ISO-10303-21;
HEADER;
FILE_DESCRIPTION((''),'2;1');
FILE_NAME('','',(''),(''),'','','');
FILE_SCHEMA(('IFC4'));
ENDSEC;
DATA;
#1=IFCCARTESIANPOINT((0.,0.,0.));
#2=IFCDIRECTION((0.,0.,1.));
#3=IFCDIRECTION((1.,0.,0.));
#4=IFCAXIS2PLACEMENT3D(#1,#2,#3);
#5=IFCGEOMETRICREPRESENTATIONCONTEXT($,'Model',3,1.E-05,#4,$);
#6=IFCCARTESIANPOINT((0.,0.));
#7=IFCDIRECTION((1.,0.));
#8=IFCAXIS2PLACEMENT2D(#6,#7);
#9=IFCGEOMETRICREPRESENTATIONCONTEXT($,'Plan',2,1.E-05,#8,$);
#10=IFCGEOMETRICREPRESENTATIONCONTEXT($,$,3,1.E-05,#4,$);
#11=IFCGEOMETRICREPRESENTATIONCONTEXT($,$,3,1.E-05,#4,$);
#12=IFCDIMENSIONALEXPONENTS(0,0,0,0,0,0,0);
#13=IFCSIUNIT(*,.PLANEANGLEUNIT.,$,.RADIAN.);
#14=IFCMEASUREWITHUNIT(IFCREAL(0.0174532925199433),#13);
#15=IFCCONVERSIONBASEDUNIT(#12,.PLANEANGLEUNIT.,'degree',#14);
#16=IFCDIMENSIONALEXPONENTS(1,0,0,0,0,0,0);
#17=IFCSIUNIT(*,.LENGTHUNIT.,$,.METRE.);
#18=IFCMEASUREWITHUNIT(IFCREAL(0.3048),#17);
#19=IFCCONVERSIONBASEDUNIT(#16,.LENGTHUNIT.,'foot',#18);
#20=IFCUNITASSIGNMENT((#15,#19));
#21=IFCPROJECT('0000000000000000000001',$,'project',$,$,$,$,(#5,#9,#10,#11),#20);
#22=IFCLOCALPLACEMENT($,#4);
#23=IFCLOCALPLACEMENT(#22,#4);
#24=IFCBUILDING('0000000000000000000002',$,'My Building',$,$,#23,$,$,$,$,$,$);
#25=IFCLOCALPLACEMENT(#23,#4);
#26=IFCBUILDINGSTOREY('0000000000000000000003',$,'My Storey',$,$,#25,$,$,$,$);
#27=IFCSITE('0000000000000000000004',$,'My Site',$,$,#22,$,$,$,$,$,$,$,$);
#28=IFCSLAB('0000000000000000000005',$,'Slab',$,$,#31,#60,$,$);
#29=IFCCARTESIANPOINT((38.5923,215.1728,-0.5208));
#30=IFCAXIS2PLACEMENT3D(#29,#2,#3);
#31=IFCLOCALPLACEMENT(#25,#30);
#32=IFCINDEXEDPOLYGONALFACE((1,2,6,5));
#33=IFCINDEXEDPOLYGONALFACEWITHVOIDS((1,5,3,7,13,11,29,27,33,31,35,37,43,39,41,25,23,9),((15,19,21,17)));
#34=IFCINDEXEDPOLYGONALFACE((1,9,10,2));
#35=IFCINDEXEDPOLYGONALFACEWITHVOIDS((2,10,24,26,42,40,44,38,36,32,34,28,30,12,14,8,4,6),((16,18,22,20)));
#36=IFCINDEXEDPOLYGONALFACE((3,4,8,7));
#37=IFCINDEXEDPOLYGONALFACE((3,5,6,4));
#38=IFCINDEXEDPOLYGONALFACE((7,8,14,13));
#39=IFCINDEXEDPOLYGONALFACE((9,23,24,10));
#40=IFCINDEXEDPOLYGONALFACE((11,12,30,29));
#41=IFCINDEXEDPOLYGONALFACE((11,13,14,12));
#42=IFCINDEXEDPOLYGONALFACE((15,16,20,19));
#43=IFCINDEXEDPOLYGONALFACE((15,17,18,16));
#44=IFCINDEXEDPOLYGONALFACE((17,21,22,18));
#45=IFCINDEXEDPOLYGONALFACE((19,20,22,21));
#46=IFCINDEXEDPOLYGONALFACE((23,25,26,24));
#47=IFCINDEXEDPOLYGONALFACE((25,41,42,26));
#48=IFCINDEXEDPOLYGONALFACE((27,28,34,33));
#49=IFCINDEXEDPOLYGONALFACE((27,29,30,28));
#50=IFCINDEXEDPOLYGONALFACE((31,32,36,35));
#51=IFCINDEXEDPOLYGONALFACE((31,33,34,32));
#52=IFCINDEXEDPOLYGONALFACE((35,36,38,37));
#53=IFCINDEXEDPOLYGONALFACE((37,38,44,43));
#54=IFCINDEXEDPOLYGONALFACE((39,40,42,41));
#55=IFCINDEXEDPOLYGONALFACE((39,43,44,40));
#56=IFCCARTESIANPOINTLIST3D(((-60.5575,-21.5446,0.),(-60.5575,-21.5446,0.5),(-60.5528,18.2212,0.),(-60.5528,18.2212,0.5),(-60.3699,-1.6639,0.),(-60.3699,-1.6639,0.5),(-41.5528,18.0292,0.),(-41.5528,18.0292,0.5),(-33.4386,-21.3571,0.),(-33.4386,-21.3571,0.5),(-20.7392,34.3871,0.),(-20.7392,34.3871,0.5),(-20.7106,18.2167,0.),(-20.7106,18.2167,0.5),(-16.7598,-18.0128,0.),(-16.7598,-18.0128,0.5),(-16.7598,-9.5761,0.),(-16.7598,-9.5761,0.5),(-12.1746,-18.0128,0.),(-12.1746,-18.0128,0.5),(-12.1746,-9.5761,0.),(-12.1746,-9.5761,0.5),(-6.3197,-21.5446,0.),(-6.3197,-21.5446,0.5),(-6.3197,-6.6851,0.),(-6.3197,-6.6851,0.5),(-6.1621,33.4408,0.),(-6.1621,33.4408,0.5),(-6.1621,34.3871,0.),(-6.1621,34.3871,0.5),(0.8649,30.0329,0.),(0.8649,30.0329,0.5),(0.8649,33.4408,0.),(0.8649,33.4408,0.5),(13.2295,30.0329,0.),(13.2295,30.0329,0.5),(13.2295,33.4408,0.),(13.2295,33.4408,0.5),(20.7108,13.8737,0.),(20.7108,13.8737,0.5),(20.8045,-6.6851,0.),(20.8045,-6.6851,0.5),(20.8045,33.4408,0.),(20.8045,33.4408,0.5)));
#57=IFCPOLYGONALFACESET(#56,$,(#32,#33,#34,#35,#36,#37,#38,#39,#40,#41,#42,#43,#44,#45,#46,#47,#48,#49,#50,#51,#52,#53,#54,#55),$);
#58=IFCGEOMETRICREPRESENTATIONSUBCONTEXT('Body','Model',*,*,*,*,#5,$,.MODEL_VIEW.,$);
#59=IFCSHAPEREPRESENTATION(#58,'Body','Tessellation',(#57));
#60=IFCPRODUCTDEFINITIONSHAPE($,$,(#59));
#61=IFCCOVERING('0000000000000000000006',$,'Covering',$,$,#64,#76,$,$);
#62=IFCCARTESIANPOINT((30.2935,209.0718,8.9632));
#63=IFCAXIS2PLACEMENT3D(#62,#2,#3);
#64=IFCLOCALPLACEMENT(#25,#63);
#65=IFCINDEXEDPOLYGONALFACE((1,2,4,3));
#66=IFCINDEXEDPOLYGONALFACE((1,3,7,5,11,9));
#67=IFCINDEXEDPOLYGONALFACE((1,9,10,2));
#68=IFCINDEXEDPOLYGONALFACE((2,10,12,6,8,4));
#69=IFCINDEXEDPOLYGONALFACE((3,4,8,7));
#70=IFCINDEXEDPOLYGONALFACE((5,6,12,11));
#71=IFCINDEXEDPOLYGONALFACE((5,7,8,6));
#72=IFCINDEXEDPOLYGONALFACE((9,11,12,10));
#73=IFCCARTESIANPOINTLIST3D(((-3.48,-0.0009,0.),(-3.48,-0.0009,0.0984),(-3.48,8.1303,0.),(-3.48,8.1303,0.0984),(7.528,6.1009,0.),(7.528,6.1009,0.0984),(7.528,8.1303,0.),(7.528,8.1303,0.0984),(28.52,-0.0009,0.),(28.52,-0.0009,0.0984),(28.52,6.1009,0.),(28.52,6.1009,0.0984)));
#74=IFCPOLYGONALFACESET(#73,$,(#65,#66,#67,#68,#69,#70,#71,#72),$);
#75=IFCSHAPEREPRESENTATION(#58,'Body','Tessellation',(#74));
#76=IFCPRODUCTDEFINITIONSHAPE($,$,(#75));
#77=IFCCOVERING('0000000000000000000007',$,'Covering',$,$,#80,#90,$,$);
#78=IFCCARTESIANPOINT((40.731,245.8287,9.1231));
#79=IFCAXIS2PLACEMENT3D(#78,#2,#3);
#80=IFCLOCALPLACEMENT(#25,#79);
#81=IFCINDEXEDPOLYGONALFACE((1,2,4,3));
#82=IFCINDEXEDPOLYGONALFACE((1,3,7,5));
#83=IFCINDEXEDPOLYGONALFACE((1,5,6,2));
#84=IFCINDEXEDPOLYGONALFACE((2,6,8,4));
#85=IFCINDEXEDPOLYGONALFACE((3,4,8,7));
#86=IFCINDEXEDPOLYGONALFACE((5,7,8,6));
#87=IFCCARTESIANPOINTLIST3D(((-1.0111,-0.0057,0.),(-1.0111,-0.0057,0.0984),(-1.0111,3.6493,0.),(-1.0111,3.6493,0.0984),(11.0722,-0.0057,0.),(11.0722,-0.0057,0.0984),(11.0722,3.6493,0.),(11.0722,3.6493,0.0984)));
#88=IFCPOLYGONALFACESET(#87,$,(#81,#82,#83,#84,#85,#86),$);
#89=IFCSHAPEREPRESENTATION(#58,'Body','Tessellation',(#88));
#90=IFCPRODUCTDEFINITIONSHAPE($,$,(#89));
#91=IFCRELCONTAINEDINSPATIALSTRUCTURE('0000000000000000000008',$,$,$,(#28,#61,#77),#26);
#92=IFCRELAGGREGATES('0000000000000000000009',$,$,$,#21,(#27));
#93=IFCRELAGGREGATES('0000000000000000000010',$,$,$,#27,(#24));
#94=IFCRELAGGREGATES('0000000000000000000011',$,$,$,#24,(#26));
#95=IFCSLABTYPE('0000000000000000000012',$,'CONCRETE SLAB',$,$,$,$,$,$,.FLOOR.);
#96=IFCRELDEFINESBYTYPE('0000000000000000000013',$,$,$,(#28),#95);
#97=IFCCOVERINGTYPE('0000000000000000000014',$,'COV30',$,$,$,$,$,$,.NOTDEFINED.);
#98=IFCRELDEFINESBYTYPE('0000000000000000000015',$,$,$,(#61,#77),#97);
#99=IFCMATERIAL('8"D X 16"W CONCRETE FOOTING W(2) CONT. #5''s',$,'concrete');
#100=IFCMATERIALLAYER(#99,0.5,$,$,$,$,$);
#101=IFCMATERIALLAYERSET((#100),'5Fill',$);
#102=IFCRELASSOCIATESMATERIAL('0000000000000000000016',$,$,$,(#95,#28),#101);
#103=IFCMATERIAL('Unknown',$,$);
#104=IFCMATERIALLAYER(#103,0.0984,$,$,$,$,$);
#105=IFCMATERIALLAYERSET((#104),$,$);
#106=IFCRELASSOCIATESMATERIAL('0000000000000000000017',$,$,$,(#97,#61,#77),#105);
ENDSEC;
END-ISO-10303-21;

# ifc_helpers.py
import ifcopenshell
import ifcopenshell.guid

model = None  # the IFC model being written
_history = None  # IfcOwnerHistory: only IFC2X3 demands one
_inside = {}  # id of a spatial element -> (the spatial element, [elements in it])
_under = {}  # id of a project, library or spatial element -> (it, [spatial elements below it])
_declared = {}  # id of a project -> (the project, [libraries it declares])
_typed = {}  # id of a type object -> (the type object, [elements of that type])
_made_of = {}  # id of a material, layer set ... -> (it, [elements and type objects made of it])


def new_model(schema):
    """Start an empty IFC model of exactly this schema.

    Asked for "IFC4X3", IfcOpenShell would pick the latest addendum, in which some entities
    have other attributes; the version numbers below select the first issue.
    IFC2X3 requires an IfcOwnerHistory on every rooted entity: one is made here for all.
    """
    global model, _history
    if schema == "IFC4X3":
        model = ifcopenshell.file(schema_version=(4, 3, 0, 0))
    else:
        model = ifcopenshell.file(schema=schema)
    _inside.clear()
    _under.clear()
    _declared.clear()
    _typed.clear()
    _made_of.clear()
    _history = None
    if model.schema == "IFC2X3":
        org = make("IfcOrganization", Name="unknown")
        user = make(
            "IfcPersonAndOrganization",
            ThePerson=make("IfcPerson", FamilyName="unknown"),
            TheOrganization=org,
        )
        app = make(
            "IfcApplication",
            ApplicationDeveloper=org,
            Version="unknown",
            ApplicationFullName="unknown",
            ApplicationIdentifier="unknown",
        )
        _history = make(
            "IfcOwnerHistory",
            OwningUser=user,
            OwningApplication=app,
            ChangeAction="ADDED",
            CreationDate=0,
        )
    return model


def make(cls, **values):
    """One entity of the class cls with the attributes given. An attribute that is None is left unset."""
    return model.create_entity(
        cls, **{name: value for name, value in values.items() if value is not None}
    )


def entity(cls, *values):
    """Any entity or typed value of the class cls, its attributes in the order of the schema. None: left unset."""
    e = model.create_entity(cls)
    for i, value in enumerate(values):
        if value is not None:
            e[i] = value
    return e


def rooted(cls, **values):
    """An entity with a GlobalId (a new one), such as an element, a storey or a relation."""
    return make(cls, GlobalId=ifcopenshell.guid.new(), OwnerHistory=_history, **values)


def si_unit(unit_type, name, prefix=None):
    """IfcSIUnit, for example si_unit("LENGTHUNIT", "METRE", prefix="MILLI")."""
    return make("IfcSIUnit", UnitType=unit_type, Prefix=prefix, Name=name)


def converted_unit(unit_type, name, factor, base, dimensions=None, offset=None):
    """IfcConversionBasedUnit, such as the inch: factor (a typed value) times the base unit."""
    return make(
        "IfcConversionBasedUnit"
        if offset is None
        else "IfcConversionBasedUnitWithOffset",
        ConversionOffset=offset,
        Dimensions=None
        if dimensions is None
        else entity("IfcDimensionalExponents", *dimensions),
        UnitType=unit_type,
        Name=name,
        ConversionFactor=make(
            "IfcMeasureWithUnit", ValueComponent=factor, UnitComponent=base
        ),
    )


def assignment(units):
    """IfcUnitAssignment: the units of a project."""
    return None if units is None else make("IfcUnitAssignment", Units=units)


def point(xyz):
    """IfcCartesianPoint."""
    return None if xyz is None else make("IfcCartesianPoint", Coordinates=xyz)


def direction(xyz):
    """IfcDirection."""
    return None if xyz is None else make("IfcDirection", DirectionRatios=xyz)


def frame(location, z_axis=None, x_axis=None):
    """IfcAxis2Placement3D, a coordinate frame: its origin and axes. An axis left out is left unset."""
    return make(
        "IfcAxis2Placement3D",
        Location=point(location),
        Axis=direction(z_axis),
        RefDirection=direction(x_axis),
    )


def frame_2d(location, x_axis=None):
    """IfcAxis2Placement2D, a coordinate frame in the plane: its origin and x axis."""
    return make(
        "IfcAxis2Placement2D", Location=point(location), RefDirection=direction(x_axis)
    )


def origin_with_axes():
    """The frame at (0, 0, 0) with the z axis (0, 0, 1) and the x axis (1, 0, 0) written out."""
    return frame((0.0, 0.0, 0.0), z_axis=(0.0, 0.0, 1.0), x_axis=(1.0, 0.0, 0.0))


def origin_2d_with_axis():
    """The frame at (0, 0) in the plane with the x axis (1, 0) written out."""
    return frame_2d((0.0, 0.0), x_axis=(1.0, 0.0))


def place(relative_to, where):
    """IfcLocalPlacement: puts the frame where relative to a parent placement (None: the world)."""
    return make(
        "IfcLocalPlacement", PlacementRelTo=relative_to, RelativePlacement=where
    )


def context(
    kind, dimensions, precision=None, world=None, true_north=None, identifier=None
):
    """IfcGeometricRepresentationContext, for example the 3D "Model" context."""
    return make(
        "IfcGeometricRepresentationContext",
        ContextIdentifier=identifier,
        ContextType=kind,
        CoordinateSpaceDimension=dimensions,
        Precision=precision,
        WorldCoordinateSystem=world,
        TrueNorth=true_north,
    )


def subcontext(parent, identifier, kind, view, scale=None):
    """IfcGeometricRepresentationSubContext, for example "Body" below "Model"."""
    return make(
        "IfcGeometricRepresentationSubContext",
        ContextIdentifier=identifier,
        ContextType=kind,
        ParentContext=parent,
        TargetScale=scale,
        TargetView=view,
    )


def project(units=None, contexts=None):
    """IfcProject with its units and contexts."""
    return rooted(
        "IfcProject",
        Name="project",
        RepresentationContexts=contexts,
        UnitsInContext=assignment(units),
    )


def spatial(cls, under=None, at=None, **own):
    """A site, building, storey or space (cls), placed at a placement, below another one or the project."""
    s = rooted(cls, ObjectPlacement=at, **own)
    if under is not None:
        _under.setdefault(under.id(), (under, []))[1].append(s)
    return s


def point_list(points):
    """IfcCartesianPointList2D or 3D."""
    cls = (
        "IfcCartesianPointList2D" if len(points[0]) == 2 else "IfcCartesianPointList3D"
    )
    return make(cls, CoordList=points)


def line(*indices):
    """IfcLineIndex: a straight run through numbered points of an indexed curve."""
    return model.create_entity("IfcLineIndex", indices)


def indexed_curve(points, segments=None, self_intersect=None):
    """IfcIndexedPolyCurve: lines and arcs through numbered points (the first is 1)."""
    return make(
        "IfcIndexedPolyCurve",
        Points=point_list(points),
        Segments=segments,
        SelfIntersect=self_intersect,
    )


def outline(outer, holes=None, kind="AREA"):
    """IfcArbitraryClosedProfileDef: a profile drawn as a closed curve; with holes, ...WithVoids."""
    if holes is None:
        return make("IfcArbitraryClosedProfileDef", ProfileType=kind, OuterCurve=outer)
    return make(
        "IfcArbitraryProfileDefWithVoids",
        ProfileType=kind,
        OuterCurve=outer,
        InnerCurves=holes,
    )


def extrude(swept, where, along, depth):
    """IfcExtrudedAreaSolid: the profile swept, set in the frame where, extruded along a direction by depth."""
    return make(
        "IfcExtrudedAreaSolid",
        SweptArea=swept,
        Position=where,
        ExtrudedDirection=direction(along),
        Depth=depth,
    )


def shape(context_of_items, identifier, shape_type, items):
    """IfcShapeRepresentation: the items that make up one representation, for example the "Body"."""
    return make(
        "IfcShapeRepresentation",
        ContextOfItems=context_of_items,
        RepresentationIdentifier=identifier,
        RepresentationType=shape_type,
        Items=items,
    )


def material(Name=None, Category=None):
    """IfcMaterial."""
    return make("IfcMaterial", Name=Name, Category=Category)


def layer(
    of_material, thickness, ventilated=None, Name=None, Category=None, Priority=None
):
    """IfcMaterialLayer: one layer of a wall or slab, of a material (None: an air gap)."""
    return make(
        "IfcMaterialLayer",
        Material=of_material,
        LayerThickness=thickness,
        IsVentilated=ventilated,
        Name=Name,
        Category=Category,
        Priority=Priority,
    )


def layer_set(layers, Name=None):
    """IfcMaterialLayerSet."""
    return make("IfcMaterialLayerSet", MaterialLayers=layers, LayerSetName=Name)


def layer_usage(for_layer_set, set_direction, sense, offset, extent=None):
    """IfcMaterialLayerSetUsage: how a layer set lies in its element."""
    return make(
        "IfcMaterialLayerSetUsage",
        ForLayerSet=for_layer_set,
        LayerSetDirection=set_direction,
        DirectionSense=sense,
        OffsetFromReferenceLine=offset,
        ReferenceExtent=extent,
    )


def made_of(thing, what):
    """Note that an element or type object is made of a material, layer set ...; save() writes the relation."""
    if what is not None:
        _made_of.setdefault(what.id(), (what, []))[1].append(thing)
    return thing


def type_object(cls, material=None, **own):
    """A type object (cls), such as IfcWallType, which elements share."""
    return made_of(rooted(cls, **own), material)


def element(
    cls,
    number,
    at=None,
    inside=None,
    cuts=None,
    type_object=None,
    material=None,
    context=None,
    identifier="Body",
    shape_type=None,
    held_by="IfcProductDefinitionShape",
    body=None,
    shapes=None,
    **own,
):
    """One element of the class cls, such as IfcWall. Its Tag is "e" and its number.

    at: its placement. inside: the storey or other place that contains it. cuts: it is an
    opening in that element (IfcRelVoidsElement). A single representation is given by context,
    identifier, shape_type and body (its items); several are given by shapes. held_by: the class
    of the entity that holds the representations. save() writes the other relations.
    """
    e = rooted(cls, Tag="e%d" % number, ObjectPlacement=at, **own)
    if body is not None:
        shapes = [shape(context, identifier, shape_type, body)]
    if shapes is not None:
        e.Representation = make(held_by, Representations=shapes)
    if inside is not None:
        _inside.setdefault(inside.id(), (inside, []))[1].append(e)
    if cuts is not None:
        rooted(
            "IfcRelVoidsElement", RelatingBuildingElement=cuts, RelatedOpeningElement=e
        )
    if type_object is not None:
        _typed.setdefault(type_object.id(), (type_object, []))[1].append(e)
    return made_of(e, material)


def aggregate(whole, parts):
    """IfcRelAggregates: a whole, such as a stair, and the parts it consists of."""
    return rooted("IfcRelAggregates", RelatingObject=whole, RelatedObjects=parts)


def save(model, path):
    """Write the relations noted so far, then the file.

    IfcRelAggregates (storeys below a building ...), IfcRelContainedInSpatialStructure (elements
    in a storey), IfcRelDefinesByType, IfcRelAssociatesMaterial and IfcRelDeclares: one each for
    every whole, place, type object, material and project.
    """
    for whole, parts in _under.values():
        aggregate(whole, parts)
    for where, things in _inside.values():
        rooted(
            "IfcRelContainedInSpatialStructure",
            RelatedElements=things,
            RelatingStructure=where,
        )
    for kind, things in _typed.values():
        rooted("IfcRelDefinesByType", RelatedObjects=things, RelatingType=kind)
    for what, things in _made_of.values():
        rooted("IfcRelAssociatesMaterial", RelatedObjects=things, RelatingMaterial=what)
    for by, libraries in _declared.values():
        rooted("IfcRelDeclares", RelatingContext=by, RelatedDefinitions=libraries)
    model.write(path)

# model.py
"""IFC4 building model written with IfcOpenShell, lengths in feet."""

from ifc_helpers import new_model, entity, si_unit, converted_unit, frame, origin_with_axes, origin_2d_with_axis, place, context, subcontext, project, spatial, line, indexed_curve, outline, extrude, material, layer, layer_set, layer_usage, type_object, element, save


model = new_model("IFC4")

# Units and contexts
model_context = context("Model", 3, precision=1e-05, world=origin_with_axes())
plan_context = context("Plan", 2, precision=1e-05, world=origin_2d_with_axis())
context_of_model_1 = context(None, 3, precision=1e-05, world=origin_with_axes())
context_of_model_2 = context(None, 3, precision=1e-05, world=origin_with_axes())
body_context = subcontext(model_context, "Body", "Model", "MODEL_VIEW")
ifc_project = project(units=[converted_unit("PLANEANGLEUNIT", "degree", entity("IfcReal", 0.0174532925199433), si_unit("PLANEANGLEUNIT", "RADIAN"), dimensions=[0, 0, 0, 0, 0, 0, 0]), converted_unit("LENGTHUNIT", "foot", entity("IfcReal", 0.3048), si_unit("LENGTHUNIT", "METRE"), dimensions=[1, 0, 0, 0, 0, 0, 0])], contexts=[model_context, plan_context, context_of_model_1, context_of_model_2])

# Site, building, storey
site_placement = place(None, origin_with_axes())
site = spatial("IfcSite", under=ifc_project, at=site_placement, Name="My Site")
building_placement = place(site_placement, origin_with_axes())
building = spatial("IfcBuilding", under=site, at=building_placement, Name="My Building")
storey_placement = place(building_placement, origin_with_axes())
storey = spatial("IfcBuildingStorey", under=building, at=storey_placement, Name="My Storey")

# Slab
ifc_material_1 = material(Name="8\"D X 16\"W CONCRETE FOOTING W(2) CONT. #5's", Category="concrete")
ifc_layer_1 = layer(ifc_material_1, 0.5)
ifc_layer_set_1 = layer_set([ifc_layer_1], Name="5Fill")
ifc_layer_usage_1 = layer_usage(ifc_layer_set_1, "AXIS3", "POSITIVE", 0.0)
slab_type_1 = type_object("IfcSlabType", Name="CONCRETE SLAB", PredefinedType="FLOOR", material=ifc_layer_set_1)
slab_1_placement = place(storey_placement, frame((38.5923, 215.1728, -0.5208), z_axis=(0.0, 0.0, 1.0), x_axis=(1.0, 0.0, 0.0)))
element("IfcSlab", 1, at=slab_1_placement, inside=storey, type_object=slab_type_1, material=ifc_layer_usage_1, Name="Slab", context=body_context, shape_type="SweptSolid", body=[
    extrude(outline(indexed_curve([(-41.5528, 18.0292), (-60.5528, 18.2212), (-60.3699, -1.6639), (-60.5575, -21.5446), (-33.4386, -21.3571), (-6.3197, -21.5446), (-6.3197, -6.6851), (20.8045, -6.6851), (20.7108, 13.8737), (20.8045, 33.4408), (13.2295, 33.4408), (13.2295, 30.0329), (0.8649, 30.0329), (0.8649, 33.4408), (-6.1621, 33.4408), (-6.1621, 34.3871), (-20.7392, 34.3871), (-20.7106, 18.2167), (-16.7598, -18.0128), (-16.7598, -9.5761), (-12.1746, -9.5761), (-12.1746, -18.0128)], segments=[line(17, 16), line(16, 15), line(15, 14), line(14, 13), line(13, 12), line(12, 11), line(11, 10), line(10, 9), line(9, 8), line(8, 7), line(7, 6), line(6, 5), line(5, 4), line(4, 3), line(3, 2), line(2, 1), line(1, 18), line(18, 17)], self_intersect=False), holes=[indexed_curve([(-41.5528, 18.0292), (-60.5528, 18.2212), (-60.3699, -1.6639), (-60.5575, -21.5446), (-33.4386, -21.3571), (-6.3197, -21.5446), (-6.3197, -6.6851), (20.8045, -6.6851), (20.7108, 13.8737), (20.8045, 33.4408), (13.2295, 33.4408), (13.2295, 30.0329), (0.8649, 30.0329), (0.8649, 33.4408), (-6.1621, 33.4408), (-6.1621, 34.3871), (-20.7392, 34.3871), (-20.7106, 18.2167), (-16.7598, -18.0128), (-16.7598, -9.5761), (-12.1746, -9.5761), (-12.1746, -18.0128)], segments=[line(22, 21), line(21, 20), line(20, 19), line(19, 22)], self_intersect=False)]), None, (0.0, 0.0, 1.0), 0.5),
])

# Coverings
ifc_material_2 = material(Name="Unknown")
ifc_layer_2 = layer(ifc_material_2, 0.0984)
ifc_layer_set_2 = layer_set([ifc_layer_2])
ifc_layer_usage_2 = layer_usage(ifc_layer_set_2, "AXIS3", "POSITIVE", 0.0)
covering_type = type_object("IfcCoveringType", Name="COV30", PredefinedType="NOTDEFINED", material=ifc_layer_set_2)
covering_1_placement = place(storey_placement, frame((30.2935, 209.0718, 8.9632), z_axis=(0.0, 0.0, 1.0), x_axis=(1.0, 0.0, 0.0)))
element("IfcCovering", 2, at=covering_1_placement, inside=storey, type_object=covering_type, material=ifc_layer_usage_2, Name="Covering", context=body_context, shape_type="SweptSolid", body=[
    extrude(outline(indexed_curve([(28.52, -0.0009), (28.52, 6.1009), (7.528, 6.1009), (7.528, 8.1303), (-3.48, 8.1303), (-3.48, -0.0009)], segments=[line(6, 5), line(5, 4), line(4, 3), line(3, 2), line(2, 1), line(1, 6)], self_intersect=False)), None, (0.0, 0.0, 1.0), 0.0984),
])
ifc_layer_usage_3 = layer_usage(ifc_layer_set_2, "AXIS3", "POSITIVE", 0.0)
covering_2_placement = place(storey_placement, frame((40.731, 245.8287, 9.1231), z_axis=(0.0, 0.0, 1.0), x_axis=(1.0, 0.0, 0.0)))
element("IfcCovering", 3, at=covering_2_placement, inside=storey, type_object=covering_type, material=ifc_layer_usage_3, Name="Covering", context=body_context, shape_type="SweptSolid", body=[
    extrude(outline(indexed_curve([(-1.0111, 3.6493), (-1.0111, -0.0057), (11.0722, -0.0057), (11.0722, 3.6493)], segments=[line(4, 1), line(1, 2), line(2, 3), line(3, 4)], self_intersect=False)), None, (0.0, 0.0, 1.0), 0.0984),
])

save(model, "model.ifc")
